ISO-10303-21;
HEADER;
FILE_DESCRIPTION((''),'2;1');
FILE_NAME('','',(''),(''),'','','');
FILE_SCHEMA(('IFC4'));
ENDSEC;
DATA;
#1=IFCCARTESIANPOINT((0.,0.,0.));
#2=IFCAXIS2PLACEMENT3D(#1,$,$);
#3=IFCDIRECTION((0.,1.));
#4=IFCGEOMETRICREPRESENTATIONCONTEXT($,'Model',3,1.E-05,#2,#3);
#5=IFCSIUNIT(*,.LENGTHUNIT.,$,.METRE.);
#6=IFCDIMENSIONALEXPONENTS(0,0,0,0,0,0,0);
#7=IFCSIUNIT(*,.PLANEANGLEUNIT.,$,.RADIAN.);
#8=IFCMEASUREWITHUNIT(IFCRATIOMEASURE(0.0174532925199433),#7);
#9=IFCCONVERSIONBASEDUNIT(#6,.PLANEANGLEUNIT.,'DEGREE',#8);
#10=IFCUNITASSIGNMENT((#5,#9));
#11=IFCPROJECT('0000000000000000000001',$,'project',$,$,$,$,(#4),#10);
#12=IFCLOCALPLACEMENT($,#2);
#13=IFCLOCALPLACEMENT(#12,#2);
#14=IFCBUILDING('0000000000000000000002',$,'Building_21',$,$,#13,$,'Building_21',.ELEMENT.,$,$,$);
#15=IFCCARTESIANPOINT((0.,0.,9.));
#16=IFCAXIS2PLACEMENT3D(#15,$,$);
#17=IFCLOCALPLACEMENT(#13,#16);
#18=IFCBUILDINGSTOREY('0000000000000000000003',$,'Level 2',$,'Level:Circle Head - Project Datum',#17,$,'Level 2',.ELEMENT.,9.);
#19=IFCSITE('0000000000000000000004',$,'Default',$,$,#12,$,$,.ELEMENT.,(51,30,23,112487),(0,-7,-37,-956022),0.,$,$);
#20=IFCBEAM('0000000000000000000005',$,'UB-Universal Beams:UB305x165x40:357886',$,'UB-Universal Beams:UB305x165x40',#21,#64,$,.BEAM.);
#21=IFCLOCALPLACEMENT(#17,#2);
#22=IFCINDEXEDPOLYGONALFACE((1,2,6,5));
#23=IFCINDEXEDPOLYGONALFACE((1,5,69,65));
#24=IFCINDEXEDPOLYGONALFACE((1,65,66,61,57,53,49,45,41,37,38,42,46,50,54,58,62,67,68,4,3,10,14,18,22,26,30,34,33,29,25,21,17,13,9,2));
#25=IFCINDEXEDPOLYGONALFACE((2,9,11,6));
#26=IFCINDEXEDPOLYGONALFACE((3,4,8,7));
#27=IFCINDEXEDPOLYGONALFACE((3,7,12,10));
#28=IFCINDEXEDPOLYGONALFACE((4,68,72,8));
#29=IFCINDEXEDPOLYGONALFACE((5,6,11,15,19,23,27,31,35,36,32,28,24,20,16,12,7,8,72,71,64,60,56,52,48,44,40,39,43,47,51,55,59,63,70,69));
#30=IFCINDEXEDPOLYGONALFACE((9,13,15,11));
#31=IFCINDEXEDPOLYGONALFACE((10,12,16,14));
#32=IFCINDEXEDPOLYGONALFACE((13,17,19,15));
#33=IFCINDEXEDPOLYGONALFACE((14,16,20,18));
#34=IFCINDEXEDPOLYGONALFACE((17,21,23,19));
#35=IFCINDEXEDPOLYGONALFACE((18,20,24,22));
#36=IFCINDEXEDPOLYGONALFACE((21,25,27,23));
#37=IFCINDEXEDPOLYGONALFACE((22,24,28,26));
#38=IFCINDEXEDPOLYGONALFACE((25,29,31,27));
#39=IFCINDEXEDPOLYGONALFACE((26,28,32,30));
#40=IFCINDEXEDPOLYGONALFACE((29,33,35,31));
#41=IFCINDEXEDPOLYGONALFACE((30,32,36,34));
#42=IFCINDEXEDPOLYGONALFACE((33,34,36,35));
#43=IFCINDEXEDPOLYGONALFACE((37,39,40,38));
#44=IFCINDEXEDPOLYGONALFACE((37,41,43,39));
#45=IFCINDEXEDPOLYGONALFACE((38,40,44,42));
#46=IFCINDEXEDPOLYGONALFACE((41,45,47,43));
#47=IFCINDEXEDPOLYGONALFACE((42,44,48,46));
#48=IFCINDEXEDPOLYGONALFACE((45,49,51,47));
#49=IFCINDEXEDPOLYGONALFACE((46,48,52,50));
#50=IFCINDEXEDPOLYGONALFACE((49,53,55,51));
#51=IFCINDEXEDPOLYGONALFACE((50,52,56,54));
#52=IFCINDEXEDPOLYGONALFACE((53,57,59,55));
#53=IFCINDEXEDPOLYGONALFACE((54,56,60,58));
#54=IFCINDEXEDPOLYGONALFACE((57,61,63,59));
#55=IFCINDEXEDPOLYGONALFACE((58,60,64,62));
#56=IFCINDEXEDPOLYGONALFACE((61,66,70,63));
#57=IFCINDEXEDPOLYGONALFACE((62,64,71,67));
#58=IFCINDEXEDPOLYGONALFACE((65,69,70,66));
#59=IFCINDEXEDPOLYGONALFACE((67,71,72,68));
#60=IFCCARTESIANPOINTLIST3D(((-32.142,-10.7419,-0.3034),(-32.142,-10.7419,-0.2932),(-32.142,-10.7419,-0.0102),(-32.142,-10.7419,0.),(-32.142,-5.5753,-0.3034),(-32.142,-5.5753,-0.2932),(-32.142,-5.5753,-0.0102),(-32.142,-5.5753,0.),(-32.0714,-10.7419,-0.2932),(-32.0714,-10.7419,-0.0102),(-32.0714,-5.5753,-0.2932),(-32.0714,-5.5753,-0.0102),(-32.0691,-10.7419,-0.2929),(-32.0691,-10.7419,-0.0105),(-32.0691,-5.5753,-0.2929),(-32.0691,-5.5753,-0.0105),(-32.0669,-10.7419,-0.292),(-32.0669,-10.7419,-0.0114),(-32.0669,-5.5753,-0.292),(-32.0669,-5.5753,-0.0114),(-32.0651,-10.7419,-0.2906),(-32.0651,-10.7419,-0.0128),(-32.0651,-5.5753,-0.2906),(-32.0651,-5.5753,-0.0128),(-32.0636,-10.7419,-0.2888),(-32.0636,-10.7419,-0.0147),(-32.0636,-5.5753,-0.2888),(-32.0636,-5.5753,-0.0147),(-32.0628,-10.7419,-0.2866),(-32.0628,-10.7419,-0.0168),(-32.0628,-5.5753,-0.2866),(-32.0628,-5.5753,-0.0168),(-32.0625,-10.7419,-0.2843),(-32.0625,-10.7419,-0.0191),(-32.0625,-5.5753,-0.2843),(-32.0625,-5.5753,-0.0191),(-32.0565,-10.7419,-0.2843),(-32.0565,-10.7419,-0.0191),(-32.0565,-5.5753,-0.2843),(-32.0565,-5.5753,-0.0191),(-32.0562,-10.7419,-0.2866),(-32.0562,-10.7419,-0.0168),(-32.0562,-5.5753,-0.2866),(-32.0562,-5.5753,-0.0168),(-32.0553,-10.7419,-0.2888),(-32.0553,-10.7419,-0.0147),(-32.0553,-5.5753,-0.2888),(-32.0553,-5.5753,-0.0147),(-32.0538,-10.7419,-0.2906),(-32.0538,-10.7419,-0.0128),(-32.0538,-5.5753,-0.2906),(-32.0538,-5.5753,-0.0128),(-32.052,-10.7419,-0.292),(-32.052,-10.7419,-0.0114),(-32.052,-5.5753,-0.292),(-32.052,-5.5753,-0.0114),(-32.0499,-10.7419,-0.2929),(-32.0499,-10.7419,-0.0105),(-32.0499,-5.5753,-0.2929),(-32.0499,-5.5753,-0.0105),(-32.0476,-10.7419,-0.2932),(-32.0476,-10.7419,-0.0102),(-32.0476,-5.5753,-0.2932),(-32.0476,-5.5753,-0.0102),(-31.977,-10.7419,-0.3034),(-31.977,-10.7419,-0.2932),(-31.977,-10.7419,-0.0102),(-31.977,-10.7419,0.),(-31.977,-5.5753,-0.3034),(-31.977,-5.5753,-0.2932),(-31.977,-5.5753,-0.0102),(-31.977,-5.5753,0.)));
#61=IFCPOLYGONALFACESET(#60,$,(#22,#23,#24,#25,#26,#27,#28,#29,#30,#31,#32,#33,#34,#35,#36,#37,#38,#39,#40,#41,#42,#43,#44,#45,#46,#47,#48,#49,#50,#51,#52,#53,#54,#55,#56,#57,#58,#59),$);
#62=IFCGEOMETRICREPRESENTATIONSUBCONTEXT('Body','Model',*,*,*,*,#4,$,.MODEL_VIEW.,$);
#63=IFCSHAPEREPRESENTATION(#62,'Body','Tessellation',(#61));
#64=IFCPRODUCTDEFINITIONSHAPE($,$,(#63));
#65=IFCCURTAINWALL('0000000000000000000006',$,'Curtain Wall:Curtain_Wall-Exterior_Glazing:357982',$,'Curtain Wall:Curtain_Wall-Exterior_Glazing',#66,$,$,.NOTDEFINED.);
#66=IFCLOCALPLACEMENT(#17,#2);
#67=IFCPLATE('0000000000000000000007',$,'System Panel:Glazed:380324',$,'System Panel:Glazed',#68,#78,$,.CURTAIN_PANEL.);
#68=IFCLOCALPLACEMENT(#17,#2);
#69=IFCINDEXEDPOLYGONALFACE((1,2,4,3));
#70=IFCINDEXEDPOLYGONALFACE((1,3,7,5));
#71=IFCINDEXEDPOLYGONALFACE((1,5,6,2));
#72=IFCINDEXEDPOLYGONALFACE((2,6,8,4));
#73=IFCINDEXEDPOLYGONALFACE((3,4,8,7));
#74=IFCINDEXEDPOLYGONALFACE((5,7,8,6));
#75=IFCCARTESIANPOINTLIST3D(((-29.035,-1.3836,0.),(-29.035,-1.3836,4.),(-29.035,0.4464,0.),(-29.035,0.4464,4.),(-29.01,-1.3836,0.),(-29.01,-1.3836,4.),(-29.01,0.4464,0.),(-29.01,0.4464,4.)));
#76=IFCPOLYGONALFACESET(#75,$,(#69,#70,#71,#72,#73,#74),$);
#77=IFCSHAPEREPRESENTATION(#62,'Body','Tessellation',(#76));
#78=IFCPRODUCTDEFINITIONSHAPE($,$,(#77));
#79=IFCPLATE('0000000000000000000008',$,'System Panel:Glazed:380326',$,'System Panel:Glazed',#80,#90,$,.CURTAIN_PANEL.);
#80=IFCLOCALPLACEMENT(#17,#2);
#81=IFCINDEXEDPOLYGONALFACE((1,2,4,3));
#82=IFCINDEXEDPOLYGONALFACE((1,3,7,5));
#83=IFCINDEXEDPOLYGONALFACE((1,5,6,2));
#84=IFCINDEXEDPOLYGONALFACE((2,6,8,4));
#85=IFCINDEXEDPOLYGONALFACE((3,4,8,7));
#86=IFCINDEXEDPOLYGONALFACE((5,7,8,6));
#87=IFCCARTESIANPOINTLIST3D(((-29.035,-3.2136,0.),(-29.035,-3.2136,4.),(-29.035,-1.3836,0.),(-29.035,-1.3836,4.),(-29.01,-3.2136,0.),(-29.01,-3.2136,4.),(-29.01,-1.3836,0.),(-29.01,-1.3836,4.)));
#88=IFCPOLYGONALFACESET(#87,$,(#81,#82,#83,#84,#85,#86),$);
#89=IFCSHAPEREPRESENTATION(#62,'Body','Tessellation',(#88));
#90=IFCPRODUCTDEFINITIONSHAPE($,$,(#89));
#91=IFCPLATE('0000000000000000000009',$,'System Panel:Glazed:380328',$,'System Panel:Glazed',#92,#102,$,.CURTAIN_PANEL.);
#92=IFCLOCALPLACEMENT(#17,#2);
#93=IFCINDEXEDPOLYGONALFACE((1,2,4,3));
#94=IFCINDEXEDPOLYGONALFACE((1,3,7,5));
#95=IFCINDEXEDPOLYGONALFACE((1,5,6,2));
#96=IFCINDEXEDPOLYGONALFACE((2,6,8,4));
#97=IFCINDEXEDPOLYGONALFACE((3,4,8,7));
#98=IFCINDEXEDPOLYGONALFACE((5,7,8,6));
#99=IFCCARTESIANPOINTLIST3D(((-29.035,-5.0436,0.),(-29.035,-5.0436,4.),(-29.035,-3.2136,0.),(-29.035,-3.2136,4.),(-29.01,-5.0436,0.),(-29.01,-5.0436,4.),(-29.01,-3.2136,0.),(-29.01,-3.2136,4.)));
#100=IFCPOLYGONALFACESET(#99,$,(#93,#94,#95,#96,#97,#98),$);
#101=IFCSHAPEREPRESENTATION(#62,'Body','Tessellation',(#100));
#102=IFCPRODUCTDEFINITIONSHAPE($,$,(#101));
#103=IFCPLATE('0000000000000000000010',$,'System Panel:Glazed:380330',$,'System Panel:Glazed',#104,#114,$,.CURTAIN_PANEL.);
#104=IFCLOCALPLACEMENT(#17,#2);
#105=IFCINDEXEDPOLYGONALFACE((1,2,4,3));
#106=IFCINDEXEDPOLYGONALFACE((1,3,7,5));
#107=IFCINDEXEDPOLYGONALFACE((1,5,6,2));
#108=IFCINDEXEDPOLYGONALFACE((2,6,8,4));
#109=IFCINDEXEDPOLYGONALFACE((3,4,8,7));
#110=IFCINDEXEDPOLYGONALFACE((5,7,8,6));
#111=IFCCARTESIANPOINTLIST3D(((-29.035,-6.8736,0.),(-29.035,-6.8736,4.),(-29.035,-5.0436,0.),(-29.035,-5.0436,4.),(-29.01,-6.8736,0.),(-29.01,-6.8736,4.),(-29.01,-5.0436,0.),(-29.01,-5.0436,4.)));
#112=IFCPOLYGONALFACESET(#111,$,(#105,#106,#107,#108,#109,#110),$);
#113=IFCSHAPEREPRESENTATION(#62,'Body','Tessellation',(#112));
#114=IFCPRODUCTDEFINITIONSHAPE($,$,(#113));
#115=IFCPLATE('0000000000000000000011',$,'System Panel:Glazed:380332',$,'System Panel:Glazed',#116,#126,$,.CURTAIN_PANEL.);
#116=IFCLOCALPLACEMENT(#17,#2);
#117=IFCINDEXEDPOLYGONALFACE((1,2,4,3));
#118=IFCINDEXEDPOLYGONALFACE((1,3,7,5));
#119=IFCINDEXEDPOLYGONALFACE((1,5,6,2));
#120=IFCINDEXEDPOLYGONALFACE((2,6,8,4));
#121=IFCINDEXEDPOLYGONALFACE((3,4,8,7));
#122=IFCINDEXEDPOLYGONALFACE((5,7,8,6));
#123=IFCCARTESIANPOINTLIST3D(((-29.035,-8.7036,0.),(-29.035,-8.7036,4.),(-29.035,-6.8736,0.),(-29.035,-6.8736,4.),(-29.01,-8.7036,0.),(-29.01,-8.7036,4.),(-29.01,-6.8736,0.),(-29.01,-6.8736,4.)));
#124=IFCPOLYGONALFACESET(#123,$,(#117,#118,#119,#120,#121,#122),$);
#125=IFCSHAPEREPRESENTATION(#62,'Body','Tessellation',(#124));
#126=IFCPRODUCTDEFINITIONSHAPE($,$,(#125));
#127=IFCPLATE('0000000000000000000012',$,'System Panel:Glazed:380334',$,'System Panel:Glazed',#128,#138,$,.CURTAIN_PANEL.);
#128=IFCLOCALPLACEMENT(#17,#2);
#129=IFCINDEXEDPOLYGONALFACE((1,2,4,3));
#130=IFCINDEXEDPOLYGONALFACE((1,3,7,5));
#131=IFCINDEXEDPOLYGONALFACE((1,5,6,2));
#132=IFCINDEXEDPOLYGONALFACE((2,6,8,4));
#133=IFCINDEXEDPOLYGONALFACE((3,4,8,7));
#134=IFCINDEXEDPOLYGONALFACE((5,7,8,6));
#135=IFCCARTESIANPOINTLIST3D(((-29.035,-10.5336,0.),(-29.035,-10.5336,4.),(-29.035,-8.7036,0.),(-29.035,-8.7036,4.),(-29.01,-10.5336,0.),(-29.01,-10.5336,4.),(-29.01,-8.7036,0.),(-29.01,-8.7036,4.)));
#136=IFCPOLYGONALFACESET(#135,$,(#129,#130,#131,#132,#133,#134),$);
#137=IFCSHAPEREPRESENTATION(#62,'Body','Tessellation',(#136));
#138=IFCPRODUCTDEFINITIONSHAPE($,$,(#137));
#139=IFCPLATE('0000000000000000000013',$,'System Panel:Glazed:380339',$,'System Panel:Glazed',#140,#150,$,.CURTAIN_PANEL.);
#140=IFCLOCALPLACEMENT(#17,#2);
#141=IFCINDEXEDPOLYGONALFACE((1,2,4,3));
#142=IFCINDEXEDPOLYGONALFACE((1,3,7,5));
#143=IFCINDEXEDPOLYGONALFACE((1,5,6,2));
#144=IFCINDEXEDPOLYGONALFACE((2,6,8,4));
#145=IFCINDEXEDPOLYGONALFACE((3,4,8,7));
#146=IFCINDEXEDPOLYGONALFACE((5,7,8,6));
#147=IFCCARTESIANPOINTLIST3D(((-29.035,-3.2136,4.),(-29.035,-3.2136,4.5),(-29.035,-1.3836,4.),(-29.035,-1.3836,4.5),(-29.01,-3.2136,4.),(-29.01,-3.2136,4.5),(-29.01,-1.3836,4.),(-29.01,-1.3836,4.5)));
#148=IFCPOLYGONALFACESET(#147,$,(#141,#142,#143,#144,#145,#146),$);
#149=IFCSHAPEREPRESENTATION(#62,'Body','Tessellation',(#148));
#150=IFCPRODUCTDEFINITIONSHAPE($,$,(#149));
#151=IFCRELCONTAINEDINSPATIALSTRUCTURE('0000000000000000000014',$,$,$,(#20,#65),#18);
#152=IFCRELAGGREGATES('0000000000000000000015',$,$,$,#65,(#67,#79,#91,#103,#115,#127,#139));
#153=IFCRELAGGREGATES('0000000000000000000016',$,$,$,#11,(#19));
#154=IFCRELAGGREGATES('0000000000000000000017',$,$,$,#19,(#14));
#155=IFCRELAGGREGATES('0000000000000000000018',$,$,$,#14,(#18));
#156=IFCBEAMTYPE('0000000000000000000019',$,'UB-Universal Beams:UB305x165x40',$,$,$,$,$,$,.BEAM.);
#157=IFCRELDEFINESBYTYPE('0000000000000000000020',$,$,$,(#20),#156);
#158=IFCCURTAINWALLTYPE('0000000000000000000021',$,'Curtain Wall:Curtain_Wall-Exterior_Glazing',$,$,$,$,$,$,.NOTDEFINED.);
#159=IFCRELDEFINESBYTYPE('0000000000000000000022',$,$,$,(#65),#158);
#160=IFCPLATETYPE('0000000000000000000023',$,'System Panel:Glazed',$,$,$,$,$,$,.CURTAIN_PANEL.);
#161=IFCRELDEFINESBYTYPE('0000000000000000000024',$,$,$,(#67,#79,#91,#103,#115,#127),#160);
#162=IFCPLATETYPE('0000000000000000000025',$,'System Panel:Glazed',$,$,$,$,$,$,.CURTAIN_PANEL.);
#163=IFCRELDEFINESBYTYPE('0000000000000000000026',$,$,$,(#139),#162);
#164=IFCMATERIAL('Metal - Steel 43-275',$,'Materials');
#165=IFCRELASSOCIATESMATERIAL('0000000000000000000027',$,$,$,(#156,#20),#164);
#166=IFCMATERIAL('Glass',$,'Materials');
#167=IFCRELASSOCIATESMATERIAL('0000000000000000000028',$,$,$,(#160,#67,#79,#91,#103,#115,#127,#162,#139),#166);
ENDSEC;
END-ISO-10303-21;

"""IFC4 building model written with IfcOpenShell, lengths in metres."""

from ifc_helpers import new_model, entity, si_unit, converted_unit, direction, frame, frame_2d, origin, origin_2d_with_axis, place, context, subcontext, project, spatial, polyline, circle_curve, parameter, trimmed, segment, composite_curve, rectangle, i_section, outline, extrude, source, transform, mapped, material, material_profile, profile_set, profile_usage, type_object, type_shapes, element, aggregate, save


model = new_model("IFC4")

# Units and contexts
model_context = context("Model", 3, precision=1e-05, world=origin(), true_north=direction((0.0, 1.0)))
body_context = subcontext(model_context, "Body", "Model", "MODEL_VIEW")
ifc_project = project(units=[si_unit("LENGTHUNIT", "METRE"), converted_unit("PLANEANGLEUNIT", "DEGREE", entity("IfcRatioMeasure", 0.0174532925199433), si_unit("PLANEANGLEUNIT", "RADIAN"), dimensions=[0, 0, 0, 0, 0, 0, 0])], contexts=[model_context])

# Site, building, storey
site_placement = place(None, origin())
site = spatial("IfcSite", under=ifc_project, at=site_placement, Name="Default", CompositionType="ELEMENT", RefLatitude=(51, 30, 23, 112487), RefLongitude=(0, -7, -37, -956022), RefElevation=0.0)
building_placement = place(site_placement, origin())
building = spatial("IfcBuilding", under=site, at=building_placement, Name="Building_21", LongName="Building_21", CompositionType="ELEMENT")
storey_placement = place(building_placement, frame((0.0, 0.0, 9.0)))
storey = spatial("IfcBuildingStorey", under=building, at=storey_placement, Name="Level 2", ObjectType="Level:Circle Head - Project Datum", LongName="Level 2", CompositionType="ELEMENT", Elevation=9.0)

# Shared definitions
ifc_material_1 = material(Name="Metal - Steel 43-275", Category="Materials")

# Beam
ifc_material_profile_1 = material_profile(ifc_material_1, outline(composite_curve([segment(polyline([(0.0119, -0.1415, 0.0), (0.0825, -0.1415, 0.0)]), True, "CONTINUOUS"), segment(polyline([(0.0825, -0.1415, 0.0), (0.0825, -0.1517, 0.0)]), True, "CONTINUOUS"), segment(polyline([(0.0825, -0.1517, 0.0), (-0.0825, -0.1517, 0.0)]), True, "CONTINUOUS"), segment(polyline([(-0.0825, -0.1517, 0.0), (-0.0825, -0.1415, 0.0)]), True, "CONTINUOUS"), segment(polyline([(-0.0825, -0.1415, 0.0), (-0.0119, -0.1415, 0.0)]), True, "CONTINUOUS"), segment(trimmed(circle_curve(frame((-0.0119, -0.1326, 0.0), z_axis=(0.0, 0.0, 1.0), x_axis=(-1.0, 0.0, 0.0)), 0.0089), [parameter(90.0)], [parameter(180.0)], True, "PARAMETER"), True, "CONTINUOUS"), segment(polyline([(-0.003, -0.1326, 0.0), (-0.003, 0.1326, 0.0)]), True, "CONTINUOUS"), segment(trimmed(circle_curve(frame((-0.0119, 0.1326, 0.0), z_axis=(0.0, 0.0, 1.0), x_axis=(-1.0, 0.0, 0.0)), 0.0089), [parameter(180.0)], [parameter(270.0)], True, "PARAMETER"), True, "CONTINUOUS"), segment(polyline([(-0.0119, 0.1415, 0.0), (-0.0825, 0.1415, 0.0)]), True, "CONTINUOUS"), segment(polyline([(-0.0825, 0.1415, 0.0), (-0.0825, 0.1517, 0.0)]), True, "CONTINUOUS"), segment(polyline([(-0.0825, 0.1517, 0.0), (0.0825, 0.1517, 0.0)]), True, "CONTINUOUS"), segment(polyline([(0.0825, 0.1517, 0.0), (0.0825, 0.1415, 0.0)]), True, "CONTINUOUS"), segment(polyline([(0.0825, 0.1415, 0.0), (0.0119, 0.1415, 0.0)]), True, "CONTINUOUS"), segment(trimmed(circle_curve(frame((0.0119, 0.1326, 0.0), z_axis=(0.0, 0.0, 1.0), x_axis=(-1.0, 0.0, 0.0)), 0.0089), [parameter(270.0)], [parameter(0.0)], True, "PARAMETER"), True, "CONTINUOUS"), segment(polyline([(0.003, 0.1326, 0.0), (0.003, -0.1326, 0.0)]), True, "CONTINUOUS"), segment(trimmed(circle_curve(frame((0.0119, -0.1326, 0.0), z_axis=(0.0, 0.0, 1.0), x_axis=(-1.0, 0.0, 0.0)), 0.0089), [parameter(0.0)], [parameter(90.0)], True, "PARAMETER"), True, "CONTINUOUS")], self_intersect=False), kind="CURVE"), Name="UB305x165x40")
ifc_material_profile_2 = material_profile(ifc_material_1, outline(composite_curve([segment(polyline([(-1.3346, 0.0825, -0.1415), (-1.3346, 0.0825, -0.1517)]), True, "CONTINUOUS"), segment(polyline([(-1.3346, 0.0825, -0.1517), (-1.3346, -0.0825, -0.1517)]), True, "CONTINUOUS"), segment(polyline([(-1.3346, -0.0825, -0.1517), (-1.3346, -0.0825, -0.1415)]), True, "CONTINUOUS"), segment(polyline([(-1.3346, -0.0825, -0.1415), (-1.3346, -0.003, -0.1415)]), True, "CONTINUOUS"), segment(polyline([(-1.3346, -0.003, -0.1415), (-1.3346, -0.003, 0.1415)]), True, "CONTINUOUS"), segment(polyline([(-1.3346, -0.003, 0.1415), (-1.3346, -0.0825, 0.1415)]), True, "CONTINUOUS"), segment(polyline([(-1.3346, -0.0825, 0.1415), (-1.3346, -0.0825, 0.1517)]), True, "CONTINUOUS"), segment(polyline([(-1.3346, -0.0825, 0.1517), (-1.3346, 0.0825, 0.1517)]), True, "CONTINUOUS"), segment(polyline([(-1.3346, 0.0825, 0.1517), (-1.3346, 0.0825, 0.1415)]), True, "CONTINUOUS"), segment(polyline([(-1.3346, 0.0825, 0.1415), (-1.3346, 0.003, 0.1415)]), True, "CONTINUOUS"), segment(polyline([(-1.3346, 0.003, 0.1415), (-1.3346, 0.003, -0.1415)]), True, "CONTINUOUS"), segment(polyline([(-1.3346, 0.003, -0.1415), (-1.3346, 0.0825, -0.1415)]), True, "CONTINUOUS")], self_intersect=False), kind="CURVE"), Name="UB305x165x40")
ifc_profile_set_1 = profile_set([ifc_material_profile_1, ifc_material_profile_2], Name="UB305x165x40")
beam_type_1 = type_object("IfcBeamType", Name="UB-Universal Beams:UB305x165x40", PredefinedType="BEAM", material=ifc_profile_set_1)
shared_shape_1 = source(origin(), body_context, "Body", "SweptSolid", [
    extrude(i_section(OverallWidth=0.165, OverallDepth=0.3034, WebThickness=0.006, FlangeThickness=0.0102, FilletRadius=0.0089, at=frame_2d((0.0, 0.0), x_axis=(0.0, 1.0))), frame((-2.5833, 0.0, 0.0), z_axis=(1.0, 0.0, 0.0), x_axis=(0.0, 0.0, -1.0)), (0.0, 0.0, 1.0), 5.1666),
])
type_shapes(beam_type_1, [shared_shape_1])
ifc_profile_usage_1 = profile_usage(ifc_profile_set_1, cardinal=8)
beam_1_placement = place(storey_placement, frame((-32.0595, -8.1586, -0.1517), z_axis=(0.0, 0.0, 1.0), x_axis=(0.0, -1.0, 0.0)))
element("IfcBeam", 1, at=beam_1_placement, inside=storey, type_object=beam_type_1, material=ifc_profile_usage_1, Name="UB-Universal Beams:UB305x165x40:357886", ObjectType="UB-Universal Beams:UB305x165x40", PredefinedType="BEAM", context=body_context, shape_type="MappedRepresentation", body=[
    mapped(shared_shape_1, transform((0.0, 0.0, 0.0), scale=1.0)),
])

# Curtain wall, plates
curtain_wall_type = type_object("IfcCurtainWallType", Name="Curtain Wall:Curtain_Wall-Exterior_Glazing", PredefinedType="NOTDEFINED")
curtain_wall_placement = place(storey_placement, frame((0.0, 0.0, -9.0)))
curtain_wall = element("IfcCurtainWall", 2, at=curtain_wall_placement, inside=storey, type_object=curtain_wall_type, Name="Curtain Wall:Curtain_Wall-Exterior_Glazing:357982", ObjectType="Curtain Wall:Curtain_Wall-Exterior_Glazing", PredefinedType="NOTDEFINED")
ifc_material_2 = material(Name="Glass", Category="Materials")
plate_type_1 = type_object("IfcPlateType", Name="System Panel:Glazed", PredefinedType="CURTAIN_PANEL", material=ifc_material_2)
shared_shape_2 = source(origin(), body_context, "Body", "SweptSolid", [
    extrude(rectangle(XDim=0.025, YDim=1.83, at=origin_2d_with_axis()), frame((0.915, 0.0125, 0.0), z_axis=(0.0, 0.0, 1.0), x_axis=(0.0, 1.0, 0.0)), (0.0, 0.0, 1.0), 4.0),
])
type_shapes(plate_type_1, [shared_shape_2])
plate_1_placement = place(curtain_wall_placement, frame((-29.035, 0.4464, 9.0), z_axis=(0.0, 0.0, 1.0), x_axis=(0.0, -1.0, 0.0)))
plate_1 = element("IfcPlate", 3, at=plate_1_placement, type_object=plate_type_1, material=ifc_material_2, Name="System Panel:Glazed:380324", ObjectType="System Panel:Glazed", PredefinedType="CURTAIN_PANEL", context=body_context, shape_type="MappedRepresentation", body=[
    mapped(shared_shape_2, transform((0.0, 0.0, 0.0), scale=1.0)),
])
plate_2_placement = place(curtain_wall_placement, frame((-29.035, -1.3836, 9.0), z_axis=(0.0, 0.0, 1.0), x_axis=(0.0, -1.0, 0.0)))
plate_2 = element("IfcPlate", 4, at=plate_2_placement, type_object=plate_type_1, material=ifc_material_2, Name="System Panel:Glazed:380326", ObjectType="System Panel:Glazed", PredefinedType="CURTAIN_PANEL", context=body_context, shape_type="MappedRepresentation", body=[
    mapped(shared_shape_2, transform((0.0, 0.0, 0.0), scale=1.0)),
])
plate_3_placement = place(curtain_wall_placement, frame((-29.035, -3.2136, 9.0), z_axis=(0.0, 0.0, 1.0), x_axis=(0.0, -1.0, 0.0)))
plate_3 = element("IfcPlate", 5, at=plate_3_placement, type_object=plate_type_1, material=ifc_material_2, Name="System Panel:Glazed:380328", ObjectType="System Panel:Glazed", PredefinedType="CURTAIN_PANEL", context=body_context, shape_type="MappedRepresentation", body=[
    mapped(shared_shape_2, transform((0.0, 0.0, 0.0), scale=1.0)),
])
plate_4_placement = place(curtain_wall_placement, frame((-29.035, -5.0436, 9.0), z_axis=(0.0, 0.0, 1.0), x_axis=(0.0, -1.0, 0.0)))
plate_4 = element("IfcPlate", 6, at=plate_4_placement, type_object=plate_type_1, material=ifc_material_2, Name="System Panel:Glazed:380330", ObjectType="System Panel:Glazed", PredefinedType="CURTAIN_PANEL", context=body_context, shape_type="MappedRepresentation", body=[
    mapped(shared_shape_2, transform((0.0, 0.0, 0.0), scale=1.0)),
])
plate_5_placement = place(curtain_wall_placement, frame((-29.035, -6.8736, 9.0), z_axis=(0.0, 0.0, 1.0), x_axis=(0.0, -1.0, 0.0)))
plate_5 = element("IfcPlate", 7, at=plate_5_placement, type_object=plate_type_1, material=ifc_material_2, Name="System Panel:Glazed:380332", ObjectType="System Panel:Glazed", PredefinedType="CURTAIN_PANEL", context=body_context, shape_type="MappedRepresentation", body=[
    mapped(shared_shape_2, transform((0.0, 0.0, 0.0), scale=1.0)),
])
plate_6_placement = place(curtain_wall_placement, frame((-29.035, -8.7036, 9.0), z_axis=(0.0, 0.0, 1.0), x_axis=(0.0, -1.0, 0.0)))
plate_6 = element("IfcPlate", 8, at=plate_6_placement, type_object=plate_type_1, material=ifc_material_2, Name="System Panel:Glazed:380334", ObjectType="System Panel:Glazed", PredefinedType="CURTAIN_PANEL", context=body_context, shape_type="MappedRepresentation", body=[
    mapped(shared_shape_2, transform((0.0, 0.0, 0.0), scale=1.0)),
])
plate_type_2 = type_object("IfcPlateType", Name="System Panel:Glazed", PredefinedType="CURTAIN_PANEL", material=ifc_material_2)
shared_shape_3 = source(origin(), body_context, "Body", "SweptSolid", [
    extrude(rectangle(XDim=0.025, YDim=1.83, at=origin_2d_with_axis()), frame((0.915, 0.0125, 0.0), z_axis=(0.0, 0.0, 1.0), x_axis=(0.0, 1.0, 0.0)), (0.0, 0.0, 1.0), 0.5),
])
type_shapes(plate_type_2, [shared_shape_3])
plate_7_placement = place(curtain_wall_placement, frame((-29.035, -1.3836, 13.0), z_axis=(0.0, 0.0, 1.0), x_axis=(0.0, -1.0, 0.0)))
plate_7 = element("IfcPlate", 9, at=plate_7_placement, type_object=plate_type_2, material=ifc_material_2, Name="System Panel:Glazed:380339", ObjectType="System Panel:Glazed", PredefinedType="CURTAIN_PANEL", context=body_context, shape_type="MappedRepresentation", body=[
    mapped(shared_shape_3, transform((0.0, 0.0, 0.0), scale=1.0)),
])
aggregate(curtain_wall, [plate_1, plate_2, plate_3, plate_4, plate_5, plate_6, plate_7])

save(model, "model.ifc")
